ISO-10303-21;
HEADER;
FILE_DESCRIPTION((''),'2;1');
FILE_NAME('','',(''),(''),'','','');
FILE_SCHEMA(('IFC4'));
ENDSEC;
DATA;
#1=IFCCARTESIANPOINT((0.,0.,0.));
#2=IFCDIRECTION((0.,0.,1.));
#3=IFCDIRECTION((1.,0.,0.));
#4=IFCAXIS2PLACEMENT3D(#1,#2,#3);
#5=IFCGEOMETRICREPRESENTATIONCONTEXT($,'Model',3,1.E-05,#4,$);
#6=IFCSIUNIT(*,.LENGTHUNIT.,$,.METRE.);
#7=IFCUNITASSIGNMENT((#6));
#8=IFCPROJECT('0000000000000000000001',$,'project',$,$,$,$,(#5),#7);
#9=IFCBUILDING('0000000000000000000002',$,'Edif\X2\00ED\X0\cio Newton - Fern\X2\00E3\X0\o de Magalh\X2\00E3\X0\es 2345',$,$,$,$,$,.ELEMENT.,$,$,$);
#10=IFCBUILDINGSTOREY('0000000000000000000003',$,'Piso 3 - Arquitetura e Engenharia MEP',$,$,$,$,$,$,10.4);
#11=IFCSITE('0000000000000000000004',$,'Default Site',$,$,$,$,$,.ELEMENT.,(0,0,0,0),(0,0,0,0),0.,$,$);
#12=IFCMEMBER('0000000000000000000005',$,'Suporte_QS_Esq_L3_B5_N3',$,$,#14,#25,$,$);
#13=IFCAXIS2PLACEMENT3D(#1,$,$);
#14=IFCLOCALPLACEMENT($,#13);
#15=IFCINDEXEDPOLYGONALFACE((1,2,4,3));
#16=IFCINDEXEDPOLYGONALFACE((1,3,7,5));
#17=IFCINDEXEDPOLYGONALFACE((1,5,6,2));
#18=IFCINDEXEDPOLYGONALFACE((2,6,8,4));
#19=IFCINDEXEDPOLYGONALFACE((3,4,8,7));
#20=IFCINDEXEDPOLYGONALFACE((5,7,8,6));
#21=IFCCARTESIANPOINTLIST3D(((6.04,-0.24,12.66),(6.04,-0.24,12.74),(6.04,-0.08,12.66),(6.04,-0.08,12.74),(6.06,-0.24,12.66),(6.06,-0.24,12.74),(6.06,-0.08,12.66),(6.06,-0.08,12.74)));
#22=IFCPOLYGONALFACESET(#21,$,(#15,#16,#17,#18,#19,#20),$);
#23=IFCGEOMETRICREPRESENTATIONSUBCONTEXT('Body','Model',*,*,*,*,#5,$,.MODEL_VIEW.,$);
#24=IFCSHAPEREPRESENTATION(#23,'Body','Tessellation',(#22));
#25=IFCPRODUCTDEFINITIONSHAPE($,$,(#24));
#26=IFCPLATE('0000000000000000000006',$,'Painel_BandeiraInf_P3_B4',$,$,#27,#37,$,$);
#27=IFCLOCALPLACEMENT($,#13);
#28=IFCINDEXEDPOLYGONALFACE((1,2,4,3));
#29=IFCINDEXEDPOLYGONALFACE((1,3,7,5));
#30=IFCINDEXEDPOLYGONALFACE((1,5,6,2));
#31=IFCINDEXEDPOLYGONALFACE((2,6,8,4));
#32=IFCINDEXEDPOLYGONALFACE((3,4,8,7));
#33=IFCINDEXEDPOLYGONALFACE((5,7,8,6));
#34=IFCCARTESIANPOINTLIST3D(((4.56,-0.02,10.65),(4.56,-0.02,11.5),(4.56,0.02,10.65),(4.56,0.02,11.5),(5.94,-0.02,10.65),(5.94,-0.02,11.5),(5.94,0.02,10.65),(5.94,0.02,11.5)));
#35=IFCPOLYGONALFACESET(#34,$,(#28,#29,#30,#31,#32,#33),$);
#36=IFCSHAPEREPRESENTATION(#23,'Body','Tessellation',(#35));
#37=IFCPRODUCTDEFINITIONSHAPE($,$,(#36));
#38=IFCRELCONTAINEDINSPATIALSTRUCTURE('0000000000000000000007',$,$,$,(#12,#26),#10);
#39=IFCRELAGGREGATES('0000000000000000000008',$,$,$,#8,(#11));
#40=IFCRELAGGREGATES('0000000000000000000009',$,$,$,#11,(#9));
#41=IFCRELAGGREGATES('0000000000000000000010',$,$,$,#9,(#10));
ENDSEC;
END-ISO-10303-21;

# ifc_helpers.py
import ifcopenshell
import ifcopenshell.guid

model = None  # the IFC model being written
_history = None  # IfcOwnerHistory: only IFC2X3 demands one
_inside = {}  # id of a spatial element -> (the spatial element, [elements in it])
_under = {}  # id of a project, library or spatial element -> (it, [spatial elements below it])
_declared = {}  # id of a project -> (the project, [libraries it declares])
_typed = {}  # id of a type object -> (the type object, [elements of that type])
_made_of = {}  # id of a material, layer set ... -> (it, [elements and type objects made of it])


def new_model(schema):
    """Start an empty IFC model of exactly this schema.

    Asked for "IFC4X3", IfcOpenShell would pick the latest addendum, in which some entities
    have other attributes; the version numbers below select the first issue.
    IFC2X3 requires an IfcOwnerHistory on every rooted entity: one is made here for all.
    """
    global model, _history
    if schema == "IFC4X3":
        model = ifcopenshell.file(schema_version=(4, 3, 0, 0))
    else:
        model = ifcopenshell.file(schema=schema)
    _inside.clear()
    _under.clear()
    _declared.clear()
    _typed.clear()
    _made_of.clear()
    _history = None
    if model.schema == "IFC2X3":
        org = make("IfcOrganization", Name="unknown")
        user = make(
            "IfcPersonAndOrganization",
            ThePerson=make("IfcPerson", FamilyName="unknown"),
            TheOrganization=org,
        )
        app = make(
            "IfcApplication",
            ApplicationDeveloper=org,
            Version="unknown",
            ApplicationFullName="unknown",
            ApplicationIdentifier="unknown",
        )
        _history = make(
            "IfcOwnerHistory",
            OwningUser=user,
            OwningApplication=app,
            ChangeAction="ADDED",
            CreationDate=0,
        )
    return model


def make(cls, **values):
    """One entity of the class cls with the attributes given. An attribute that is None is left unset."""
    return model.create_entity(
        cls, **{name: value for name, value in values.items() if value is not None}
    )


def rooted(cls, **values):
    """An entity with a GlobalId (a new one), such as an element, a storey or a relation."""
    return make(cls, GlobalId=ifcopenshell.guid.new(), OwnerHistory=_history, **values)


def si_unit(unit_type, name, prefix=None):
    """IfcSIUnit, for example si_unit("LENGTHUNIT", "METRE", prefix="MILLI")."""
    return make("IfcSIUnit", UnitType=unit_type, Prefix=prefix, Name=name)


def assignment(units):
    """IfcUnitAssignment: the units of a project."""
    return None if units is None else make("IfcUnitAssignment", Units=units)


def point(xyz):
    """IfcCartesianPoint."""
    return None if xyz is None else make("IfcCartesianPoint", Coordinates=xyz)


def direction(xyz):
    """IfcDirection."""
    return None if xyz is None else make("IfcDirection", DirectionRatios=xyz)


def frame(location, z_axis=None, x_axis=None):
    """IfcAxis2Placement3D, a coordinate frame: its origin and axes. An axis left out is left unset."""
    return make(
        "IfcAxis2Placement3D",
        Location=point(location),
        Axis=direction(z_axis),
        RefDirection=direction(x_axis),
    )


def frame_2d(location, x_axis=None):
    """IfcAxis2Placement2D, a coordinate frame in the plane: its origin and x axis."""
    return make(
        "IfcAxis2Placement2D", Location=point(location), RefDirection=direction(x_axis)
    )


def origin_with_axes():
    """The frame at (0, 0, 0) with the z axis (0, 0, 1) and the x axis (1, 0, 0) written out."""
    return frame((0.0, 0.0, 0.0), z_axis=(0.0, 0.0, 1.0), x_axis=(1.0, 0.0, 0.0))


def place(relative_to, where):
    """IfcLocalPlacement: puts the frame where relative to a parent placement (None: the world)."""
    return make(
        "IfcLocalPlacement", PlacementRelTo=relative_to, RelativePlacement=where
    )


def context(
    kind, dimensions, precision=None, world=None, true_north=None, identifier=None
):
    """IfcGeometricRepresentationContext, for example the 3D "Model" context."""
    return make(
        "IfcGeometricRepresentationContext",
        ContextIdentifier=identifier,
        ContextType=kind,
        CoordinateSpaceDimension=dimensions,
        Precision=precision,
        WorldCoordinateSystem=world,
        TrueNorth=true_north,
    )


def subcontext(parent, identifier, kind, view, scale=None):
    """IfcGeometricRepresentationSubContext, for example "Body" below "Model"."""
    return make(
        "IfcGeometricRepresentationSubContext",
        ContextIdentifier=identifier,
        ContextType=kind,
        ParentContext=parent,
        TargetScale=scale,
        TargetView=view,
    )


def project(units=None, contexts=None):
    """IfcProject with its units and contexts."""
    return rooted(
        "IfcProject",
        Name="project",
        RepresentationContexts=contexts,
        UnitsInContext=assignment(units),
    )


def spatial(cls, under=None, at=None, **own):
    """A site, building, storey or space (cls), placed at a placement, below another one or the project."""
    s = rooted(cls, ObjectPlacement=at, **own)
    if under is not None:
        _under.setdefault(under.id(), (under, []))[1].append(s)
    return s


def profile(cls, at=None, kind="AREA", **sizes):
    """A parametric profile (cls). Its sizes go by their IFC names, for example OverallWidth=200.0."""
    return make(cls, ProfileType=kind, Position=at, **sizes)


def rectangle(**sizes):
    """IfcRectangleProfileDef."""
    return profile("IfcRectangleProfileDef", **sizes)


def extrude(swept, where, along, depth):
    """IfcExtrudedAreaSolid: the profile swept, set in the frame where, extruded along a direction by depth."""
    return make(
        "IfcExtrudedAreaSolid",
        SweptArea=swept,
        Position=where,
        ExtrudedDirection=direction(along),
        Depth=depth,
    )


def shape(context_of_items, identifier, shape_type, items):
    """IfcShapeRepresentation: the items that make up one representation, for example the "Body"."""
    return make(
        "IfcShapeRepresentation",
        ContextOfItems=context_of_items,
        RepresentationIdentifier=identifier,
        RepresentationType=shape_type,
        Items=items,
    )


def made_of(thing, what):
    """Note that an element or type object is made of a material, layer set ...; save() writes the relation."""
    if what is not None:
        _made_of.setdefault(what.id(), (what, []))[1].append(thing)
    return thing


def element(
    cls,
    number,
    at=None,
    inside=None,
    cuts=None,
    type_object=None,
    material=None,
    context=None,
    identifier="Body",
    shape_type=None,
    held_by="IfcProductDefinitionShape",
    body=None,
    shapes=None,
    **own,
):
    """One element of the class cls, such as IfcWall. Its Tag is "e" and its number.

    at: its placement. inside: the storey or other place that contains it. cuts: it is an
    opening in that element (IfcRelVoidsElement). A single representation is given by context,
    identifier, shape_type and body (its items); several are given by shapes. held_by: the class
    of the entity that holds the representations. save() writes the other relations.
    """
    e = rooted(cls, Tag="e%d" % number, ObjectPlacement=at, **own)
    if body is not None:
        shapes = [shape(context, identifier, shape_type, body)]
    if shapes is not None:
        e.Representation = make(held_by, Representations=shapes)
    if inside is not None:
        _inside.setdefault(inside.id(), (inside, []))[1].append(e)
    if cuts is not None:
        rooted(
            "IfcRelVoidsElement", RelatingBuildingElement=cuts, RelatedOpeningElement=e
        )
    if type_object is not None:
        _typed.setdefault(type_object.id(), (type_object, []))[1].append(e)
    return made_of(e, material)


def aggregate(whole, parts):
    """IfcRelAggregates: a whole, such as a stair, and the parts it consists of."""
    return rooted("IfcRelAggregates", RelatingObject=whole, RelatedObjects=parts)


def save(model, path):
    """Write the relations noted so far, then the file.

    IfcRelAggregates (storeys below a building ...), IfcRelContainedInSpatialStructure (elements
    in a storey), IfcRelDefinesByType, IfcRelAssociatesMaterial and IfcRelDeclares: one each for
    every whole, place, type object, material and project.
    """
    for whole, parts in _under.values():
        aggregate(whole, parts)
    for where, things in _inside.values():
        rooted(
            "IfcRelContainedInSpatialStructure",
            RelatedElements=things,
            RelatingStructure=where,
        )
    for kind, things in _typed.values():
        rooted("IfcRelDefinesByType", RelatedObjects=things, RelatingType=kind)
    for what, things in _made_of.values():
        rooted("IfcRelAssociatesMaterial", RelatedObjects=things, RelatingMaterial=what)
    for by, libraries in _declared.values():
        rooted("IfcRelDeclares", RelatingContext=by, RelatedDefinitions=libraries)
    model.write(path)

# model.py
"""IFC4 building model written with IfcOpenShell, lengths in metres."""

from ifc_helpers import new_model, si_unit, frame, frame_2d, origin_with_axes, place, context, subcontext, project, spatial, rectangle, extrude, element, save


model = new_model("IFC4")

# Units and contexts
model_context = context("Model", 3, precision=1e-05, world=origin_with_axes())
body_context = subcontext(model_context, "Body", "Model", "MODEL_VIEW")
ifc_project = project(units=[si_unit("LENGTHUNIT", "METRE")], contexts=[model_context])

# Site, building, storey
site = spatial("IfcSite", under=ifc_project, Name="Default Site", CompositionType="ELEMENT", RefLatitude=(0, 0, 0, 0), RefLongitude=(0, 0, 0, 0), RefElevation=0.0)
building = spatial("IfcBuilding", under=site, Name="Edifício Newton - Fernão de Magalhães 2345", CompositionType="ELEMENT")
storey = spatial("IfcBuildingStorey", under=building, Name="Piso 3 - Arquitetura e Engenharia MEP", Elevation=10.4)

# Member
for number, where, z_axis, x_axis, name in (
    (1, (6.04, -0.24, 12.66), (0.0, 0.0, 1.0), (1.0, 0.0, 0.0), "Suporte_QS_Esq_L3_B5_N3"),
):
    element("IfcMember", number, at=place(None, frame(where, z_axis=z_axis, x_axis=x_axis)), inside=storey, Name=name, context=body_context, shape_type="SweptSolid", body=[
        extrude(rectangle(XDim=0.02, YDim=0.16, at=frame_2d((0.01, 0.08))), origin_with_axes(), (0.0, 0.0, 1.0), 0.08),
    ])

# Plate
plate_placement = place(None, frame((4.56, -0.02, 10.65), z_axis=(0.0, 0.0, 1.0), x_axis=(1.0, 0.0, 0.0)))
element("IfcPlate", 2, at=plate_placement, inside=storey, Name="Painel_BandeiraInf_P3_B4", context=body_context, shape_type="SweptSolid", body=[
    extrude(rectangle(XDim=1.38, YDim=0.04, at=frame_2d((0.69, 0.02))), origin_with_axes(), (0.0, 0.0, 1.0), 0.85),
])

save(model, "model.ifc")
